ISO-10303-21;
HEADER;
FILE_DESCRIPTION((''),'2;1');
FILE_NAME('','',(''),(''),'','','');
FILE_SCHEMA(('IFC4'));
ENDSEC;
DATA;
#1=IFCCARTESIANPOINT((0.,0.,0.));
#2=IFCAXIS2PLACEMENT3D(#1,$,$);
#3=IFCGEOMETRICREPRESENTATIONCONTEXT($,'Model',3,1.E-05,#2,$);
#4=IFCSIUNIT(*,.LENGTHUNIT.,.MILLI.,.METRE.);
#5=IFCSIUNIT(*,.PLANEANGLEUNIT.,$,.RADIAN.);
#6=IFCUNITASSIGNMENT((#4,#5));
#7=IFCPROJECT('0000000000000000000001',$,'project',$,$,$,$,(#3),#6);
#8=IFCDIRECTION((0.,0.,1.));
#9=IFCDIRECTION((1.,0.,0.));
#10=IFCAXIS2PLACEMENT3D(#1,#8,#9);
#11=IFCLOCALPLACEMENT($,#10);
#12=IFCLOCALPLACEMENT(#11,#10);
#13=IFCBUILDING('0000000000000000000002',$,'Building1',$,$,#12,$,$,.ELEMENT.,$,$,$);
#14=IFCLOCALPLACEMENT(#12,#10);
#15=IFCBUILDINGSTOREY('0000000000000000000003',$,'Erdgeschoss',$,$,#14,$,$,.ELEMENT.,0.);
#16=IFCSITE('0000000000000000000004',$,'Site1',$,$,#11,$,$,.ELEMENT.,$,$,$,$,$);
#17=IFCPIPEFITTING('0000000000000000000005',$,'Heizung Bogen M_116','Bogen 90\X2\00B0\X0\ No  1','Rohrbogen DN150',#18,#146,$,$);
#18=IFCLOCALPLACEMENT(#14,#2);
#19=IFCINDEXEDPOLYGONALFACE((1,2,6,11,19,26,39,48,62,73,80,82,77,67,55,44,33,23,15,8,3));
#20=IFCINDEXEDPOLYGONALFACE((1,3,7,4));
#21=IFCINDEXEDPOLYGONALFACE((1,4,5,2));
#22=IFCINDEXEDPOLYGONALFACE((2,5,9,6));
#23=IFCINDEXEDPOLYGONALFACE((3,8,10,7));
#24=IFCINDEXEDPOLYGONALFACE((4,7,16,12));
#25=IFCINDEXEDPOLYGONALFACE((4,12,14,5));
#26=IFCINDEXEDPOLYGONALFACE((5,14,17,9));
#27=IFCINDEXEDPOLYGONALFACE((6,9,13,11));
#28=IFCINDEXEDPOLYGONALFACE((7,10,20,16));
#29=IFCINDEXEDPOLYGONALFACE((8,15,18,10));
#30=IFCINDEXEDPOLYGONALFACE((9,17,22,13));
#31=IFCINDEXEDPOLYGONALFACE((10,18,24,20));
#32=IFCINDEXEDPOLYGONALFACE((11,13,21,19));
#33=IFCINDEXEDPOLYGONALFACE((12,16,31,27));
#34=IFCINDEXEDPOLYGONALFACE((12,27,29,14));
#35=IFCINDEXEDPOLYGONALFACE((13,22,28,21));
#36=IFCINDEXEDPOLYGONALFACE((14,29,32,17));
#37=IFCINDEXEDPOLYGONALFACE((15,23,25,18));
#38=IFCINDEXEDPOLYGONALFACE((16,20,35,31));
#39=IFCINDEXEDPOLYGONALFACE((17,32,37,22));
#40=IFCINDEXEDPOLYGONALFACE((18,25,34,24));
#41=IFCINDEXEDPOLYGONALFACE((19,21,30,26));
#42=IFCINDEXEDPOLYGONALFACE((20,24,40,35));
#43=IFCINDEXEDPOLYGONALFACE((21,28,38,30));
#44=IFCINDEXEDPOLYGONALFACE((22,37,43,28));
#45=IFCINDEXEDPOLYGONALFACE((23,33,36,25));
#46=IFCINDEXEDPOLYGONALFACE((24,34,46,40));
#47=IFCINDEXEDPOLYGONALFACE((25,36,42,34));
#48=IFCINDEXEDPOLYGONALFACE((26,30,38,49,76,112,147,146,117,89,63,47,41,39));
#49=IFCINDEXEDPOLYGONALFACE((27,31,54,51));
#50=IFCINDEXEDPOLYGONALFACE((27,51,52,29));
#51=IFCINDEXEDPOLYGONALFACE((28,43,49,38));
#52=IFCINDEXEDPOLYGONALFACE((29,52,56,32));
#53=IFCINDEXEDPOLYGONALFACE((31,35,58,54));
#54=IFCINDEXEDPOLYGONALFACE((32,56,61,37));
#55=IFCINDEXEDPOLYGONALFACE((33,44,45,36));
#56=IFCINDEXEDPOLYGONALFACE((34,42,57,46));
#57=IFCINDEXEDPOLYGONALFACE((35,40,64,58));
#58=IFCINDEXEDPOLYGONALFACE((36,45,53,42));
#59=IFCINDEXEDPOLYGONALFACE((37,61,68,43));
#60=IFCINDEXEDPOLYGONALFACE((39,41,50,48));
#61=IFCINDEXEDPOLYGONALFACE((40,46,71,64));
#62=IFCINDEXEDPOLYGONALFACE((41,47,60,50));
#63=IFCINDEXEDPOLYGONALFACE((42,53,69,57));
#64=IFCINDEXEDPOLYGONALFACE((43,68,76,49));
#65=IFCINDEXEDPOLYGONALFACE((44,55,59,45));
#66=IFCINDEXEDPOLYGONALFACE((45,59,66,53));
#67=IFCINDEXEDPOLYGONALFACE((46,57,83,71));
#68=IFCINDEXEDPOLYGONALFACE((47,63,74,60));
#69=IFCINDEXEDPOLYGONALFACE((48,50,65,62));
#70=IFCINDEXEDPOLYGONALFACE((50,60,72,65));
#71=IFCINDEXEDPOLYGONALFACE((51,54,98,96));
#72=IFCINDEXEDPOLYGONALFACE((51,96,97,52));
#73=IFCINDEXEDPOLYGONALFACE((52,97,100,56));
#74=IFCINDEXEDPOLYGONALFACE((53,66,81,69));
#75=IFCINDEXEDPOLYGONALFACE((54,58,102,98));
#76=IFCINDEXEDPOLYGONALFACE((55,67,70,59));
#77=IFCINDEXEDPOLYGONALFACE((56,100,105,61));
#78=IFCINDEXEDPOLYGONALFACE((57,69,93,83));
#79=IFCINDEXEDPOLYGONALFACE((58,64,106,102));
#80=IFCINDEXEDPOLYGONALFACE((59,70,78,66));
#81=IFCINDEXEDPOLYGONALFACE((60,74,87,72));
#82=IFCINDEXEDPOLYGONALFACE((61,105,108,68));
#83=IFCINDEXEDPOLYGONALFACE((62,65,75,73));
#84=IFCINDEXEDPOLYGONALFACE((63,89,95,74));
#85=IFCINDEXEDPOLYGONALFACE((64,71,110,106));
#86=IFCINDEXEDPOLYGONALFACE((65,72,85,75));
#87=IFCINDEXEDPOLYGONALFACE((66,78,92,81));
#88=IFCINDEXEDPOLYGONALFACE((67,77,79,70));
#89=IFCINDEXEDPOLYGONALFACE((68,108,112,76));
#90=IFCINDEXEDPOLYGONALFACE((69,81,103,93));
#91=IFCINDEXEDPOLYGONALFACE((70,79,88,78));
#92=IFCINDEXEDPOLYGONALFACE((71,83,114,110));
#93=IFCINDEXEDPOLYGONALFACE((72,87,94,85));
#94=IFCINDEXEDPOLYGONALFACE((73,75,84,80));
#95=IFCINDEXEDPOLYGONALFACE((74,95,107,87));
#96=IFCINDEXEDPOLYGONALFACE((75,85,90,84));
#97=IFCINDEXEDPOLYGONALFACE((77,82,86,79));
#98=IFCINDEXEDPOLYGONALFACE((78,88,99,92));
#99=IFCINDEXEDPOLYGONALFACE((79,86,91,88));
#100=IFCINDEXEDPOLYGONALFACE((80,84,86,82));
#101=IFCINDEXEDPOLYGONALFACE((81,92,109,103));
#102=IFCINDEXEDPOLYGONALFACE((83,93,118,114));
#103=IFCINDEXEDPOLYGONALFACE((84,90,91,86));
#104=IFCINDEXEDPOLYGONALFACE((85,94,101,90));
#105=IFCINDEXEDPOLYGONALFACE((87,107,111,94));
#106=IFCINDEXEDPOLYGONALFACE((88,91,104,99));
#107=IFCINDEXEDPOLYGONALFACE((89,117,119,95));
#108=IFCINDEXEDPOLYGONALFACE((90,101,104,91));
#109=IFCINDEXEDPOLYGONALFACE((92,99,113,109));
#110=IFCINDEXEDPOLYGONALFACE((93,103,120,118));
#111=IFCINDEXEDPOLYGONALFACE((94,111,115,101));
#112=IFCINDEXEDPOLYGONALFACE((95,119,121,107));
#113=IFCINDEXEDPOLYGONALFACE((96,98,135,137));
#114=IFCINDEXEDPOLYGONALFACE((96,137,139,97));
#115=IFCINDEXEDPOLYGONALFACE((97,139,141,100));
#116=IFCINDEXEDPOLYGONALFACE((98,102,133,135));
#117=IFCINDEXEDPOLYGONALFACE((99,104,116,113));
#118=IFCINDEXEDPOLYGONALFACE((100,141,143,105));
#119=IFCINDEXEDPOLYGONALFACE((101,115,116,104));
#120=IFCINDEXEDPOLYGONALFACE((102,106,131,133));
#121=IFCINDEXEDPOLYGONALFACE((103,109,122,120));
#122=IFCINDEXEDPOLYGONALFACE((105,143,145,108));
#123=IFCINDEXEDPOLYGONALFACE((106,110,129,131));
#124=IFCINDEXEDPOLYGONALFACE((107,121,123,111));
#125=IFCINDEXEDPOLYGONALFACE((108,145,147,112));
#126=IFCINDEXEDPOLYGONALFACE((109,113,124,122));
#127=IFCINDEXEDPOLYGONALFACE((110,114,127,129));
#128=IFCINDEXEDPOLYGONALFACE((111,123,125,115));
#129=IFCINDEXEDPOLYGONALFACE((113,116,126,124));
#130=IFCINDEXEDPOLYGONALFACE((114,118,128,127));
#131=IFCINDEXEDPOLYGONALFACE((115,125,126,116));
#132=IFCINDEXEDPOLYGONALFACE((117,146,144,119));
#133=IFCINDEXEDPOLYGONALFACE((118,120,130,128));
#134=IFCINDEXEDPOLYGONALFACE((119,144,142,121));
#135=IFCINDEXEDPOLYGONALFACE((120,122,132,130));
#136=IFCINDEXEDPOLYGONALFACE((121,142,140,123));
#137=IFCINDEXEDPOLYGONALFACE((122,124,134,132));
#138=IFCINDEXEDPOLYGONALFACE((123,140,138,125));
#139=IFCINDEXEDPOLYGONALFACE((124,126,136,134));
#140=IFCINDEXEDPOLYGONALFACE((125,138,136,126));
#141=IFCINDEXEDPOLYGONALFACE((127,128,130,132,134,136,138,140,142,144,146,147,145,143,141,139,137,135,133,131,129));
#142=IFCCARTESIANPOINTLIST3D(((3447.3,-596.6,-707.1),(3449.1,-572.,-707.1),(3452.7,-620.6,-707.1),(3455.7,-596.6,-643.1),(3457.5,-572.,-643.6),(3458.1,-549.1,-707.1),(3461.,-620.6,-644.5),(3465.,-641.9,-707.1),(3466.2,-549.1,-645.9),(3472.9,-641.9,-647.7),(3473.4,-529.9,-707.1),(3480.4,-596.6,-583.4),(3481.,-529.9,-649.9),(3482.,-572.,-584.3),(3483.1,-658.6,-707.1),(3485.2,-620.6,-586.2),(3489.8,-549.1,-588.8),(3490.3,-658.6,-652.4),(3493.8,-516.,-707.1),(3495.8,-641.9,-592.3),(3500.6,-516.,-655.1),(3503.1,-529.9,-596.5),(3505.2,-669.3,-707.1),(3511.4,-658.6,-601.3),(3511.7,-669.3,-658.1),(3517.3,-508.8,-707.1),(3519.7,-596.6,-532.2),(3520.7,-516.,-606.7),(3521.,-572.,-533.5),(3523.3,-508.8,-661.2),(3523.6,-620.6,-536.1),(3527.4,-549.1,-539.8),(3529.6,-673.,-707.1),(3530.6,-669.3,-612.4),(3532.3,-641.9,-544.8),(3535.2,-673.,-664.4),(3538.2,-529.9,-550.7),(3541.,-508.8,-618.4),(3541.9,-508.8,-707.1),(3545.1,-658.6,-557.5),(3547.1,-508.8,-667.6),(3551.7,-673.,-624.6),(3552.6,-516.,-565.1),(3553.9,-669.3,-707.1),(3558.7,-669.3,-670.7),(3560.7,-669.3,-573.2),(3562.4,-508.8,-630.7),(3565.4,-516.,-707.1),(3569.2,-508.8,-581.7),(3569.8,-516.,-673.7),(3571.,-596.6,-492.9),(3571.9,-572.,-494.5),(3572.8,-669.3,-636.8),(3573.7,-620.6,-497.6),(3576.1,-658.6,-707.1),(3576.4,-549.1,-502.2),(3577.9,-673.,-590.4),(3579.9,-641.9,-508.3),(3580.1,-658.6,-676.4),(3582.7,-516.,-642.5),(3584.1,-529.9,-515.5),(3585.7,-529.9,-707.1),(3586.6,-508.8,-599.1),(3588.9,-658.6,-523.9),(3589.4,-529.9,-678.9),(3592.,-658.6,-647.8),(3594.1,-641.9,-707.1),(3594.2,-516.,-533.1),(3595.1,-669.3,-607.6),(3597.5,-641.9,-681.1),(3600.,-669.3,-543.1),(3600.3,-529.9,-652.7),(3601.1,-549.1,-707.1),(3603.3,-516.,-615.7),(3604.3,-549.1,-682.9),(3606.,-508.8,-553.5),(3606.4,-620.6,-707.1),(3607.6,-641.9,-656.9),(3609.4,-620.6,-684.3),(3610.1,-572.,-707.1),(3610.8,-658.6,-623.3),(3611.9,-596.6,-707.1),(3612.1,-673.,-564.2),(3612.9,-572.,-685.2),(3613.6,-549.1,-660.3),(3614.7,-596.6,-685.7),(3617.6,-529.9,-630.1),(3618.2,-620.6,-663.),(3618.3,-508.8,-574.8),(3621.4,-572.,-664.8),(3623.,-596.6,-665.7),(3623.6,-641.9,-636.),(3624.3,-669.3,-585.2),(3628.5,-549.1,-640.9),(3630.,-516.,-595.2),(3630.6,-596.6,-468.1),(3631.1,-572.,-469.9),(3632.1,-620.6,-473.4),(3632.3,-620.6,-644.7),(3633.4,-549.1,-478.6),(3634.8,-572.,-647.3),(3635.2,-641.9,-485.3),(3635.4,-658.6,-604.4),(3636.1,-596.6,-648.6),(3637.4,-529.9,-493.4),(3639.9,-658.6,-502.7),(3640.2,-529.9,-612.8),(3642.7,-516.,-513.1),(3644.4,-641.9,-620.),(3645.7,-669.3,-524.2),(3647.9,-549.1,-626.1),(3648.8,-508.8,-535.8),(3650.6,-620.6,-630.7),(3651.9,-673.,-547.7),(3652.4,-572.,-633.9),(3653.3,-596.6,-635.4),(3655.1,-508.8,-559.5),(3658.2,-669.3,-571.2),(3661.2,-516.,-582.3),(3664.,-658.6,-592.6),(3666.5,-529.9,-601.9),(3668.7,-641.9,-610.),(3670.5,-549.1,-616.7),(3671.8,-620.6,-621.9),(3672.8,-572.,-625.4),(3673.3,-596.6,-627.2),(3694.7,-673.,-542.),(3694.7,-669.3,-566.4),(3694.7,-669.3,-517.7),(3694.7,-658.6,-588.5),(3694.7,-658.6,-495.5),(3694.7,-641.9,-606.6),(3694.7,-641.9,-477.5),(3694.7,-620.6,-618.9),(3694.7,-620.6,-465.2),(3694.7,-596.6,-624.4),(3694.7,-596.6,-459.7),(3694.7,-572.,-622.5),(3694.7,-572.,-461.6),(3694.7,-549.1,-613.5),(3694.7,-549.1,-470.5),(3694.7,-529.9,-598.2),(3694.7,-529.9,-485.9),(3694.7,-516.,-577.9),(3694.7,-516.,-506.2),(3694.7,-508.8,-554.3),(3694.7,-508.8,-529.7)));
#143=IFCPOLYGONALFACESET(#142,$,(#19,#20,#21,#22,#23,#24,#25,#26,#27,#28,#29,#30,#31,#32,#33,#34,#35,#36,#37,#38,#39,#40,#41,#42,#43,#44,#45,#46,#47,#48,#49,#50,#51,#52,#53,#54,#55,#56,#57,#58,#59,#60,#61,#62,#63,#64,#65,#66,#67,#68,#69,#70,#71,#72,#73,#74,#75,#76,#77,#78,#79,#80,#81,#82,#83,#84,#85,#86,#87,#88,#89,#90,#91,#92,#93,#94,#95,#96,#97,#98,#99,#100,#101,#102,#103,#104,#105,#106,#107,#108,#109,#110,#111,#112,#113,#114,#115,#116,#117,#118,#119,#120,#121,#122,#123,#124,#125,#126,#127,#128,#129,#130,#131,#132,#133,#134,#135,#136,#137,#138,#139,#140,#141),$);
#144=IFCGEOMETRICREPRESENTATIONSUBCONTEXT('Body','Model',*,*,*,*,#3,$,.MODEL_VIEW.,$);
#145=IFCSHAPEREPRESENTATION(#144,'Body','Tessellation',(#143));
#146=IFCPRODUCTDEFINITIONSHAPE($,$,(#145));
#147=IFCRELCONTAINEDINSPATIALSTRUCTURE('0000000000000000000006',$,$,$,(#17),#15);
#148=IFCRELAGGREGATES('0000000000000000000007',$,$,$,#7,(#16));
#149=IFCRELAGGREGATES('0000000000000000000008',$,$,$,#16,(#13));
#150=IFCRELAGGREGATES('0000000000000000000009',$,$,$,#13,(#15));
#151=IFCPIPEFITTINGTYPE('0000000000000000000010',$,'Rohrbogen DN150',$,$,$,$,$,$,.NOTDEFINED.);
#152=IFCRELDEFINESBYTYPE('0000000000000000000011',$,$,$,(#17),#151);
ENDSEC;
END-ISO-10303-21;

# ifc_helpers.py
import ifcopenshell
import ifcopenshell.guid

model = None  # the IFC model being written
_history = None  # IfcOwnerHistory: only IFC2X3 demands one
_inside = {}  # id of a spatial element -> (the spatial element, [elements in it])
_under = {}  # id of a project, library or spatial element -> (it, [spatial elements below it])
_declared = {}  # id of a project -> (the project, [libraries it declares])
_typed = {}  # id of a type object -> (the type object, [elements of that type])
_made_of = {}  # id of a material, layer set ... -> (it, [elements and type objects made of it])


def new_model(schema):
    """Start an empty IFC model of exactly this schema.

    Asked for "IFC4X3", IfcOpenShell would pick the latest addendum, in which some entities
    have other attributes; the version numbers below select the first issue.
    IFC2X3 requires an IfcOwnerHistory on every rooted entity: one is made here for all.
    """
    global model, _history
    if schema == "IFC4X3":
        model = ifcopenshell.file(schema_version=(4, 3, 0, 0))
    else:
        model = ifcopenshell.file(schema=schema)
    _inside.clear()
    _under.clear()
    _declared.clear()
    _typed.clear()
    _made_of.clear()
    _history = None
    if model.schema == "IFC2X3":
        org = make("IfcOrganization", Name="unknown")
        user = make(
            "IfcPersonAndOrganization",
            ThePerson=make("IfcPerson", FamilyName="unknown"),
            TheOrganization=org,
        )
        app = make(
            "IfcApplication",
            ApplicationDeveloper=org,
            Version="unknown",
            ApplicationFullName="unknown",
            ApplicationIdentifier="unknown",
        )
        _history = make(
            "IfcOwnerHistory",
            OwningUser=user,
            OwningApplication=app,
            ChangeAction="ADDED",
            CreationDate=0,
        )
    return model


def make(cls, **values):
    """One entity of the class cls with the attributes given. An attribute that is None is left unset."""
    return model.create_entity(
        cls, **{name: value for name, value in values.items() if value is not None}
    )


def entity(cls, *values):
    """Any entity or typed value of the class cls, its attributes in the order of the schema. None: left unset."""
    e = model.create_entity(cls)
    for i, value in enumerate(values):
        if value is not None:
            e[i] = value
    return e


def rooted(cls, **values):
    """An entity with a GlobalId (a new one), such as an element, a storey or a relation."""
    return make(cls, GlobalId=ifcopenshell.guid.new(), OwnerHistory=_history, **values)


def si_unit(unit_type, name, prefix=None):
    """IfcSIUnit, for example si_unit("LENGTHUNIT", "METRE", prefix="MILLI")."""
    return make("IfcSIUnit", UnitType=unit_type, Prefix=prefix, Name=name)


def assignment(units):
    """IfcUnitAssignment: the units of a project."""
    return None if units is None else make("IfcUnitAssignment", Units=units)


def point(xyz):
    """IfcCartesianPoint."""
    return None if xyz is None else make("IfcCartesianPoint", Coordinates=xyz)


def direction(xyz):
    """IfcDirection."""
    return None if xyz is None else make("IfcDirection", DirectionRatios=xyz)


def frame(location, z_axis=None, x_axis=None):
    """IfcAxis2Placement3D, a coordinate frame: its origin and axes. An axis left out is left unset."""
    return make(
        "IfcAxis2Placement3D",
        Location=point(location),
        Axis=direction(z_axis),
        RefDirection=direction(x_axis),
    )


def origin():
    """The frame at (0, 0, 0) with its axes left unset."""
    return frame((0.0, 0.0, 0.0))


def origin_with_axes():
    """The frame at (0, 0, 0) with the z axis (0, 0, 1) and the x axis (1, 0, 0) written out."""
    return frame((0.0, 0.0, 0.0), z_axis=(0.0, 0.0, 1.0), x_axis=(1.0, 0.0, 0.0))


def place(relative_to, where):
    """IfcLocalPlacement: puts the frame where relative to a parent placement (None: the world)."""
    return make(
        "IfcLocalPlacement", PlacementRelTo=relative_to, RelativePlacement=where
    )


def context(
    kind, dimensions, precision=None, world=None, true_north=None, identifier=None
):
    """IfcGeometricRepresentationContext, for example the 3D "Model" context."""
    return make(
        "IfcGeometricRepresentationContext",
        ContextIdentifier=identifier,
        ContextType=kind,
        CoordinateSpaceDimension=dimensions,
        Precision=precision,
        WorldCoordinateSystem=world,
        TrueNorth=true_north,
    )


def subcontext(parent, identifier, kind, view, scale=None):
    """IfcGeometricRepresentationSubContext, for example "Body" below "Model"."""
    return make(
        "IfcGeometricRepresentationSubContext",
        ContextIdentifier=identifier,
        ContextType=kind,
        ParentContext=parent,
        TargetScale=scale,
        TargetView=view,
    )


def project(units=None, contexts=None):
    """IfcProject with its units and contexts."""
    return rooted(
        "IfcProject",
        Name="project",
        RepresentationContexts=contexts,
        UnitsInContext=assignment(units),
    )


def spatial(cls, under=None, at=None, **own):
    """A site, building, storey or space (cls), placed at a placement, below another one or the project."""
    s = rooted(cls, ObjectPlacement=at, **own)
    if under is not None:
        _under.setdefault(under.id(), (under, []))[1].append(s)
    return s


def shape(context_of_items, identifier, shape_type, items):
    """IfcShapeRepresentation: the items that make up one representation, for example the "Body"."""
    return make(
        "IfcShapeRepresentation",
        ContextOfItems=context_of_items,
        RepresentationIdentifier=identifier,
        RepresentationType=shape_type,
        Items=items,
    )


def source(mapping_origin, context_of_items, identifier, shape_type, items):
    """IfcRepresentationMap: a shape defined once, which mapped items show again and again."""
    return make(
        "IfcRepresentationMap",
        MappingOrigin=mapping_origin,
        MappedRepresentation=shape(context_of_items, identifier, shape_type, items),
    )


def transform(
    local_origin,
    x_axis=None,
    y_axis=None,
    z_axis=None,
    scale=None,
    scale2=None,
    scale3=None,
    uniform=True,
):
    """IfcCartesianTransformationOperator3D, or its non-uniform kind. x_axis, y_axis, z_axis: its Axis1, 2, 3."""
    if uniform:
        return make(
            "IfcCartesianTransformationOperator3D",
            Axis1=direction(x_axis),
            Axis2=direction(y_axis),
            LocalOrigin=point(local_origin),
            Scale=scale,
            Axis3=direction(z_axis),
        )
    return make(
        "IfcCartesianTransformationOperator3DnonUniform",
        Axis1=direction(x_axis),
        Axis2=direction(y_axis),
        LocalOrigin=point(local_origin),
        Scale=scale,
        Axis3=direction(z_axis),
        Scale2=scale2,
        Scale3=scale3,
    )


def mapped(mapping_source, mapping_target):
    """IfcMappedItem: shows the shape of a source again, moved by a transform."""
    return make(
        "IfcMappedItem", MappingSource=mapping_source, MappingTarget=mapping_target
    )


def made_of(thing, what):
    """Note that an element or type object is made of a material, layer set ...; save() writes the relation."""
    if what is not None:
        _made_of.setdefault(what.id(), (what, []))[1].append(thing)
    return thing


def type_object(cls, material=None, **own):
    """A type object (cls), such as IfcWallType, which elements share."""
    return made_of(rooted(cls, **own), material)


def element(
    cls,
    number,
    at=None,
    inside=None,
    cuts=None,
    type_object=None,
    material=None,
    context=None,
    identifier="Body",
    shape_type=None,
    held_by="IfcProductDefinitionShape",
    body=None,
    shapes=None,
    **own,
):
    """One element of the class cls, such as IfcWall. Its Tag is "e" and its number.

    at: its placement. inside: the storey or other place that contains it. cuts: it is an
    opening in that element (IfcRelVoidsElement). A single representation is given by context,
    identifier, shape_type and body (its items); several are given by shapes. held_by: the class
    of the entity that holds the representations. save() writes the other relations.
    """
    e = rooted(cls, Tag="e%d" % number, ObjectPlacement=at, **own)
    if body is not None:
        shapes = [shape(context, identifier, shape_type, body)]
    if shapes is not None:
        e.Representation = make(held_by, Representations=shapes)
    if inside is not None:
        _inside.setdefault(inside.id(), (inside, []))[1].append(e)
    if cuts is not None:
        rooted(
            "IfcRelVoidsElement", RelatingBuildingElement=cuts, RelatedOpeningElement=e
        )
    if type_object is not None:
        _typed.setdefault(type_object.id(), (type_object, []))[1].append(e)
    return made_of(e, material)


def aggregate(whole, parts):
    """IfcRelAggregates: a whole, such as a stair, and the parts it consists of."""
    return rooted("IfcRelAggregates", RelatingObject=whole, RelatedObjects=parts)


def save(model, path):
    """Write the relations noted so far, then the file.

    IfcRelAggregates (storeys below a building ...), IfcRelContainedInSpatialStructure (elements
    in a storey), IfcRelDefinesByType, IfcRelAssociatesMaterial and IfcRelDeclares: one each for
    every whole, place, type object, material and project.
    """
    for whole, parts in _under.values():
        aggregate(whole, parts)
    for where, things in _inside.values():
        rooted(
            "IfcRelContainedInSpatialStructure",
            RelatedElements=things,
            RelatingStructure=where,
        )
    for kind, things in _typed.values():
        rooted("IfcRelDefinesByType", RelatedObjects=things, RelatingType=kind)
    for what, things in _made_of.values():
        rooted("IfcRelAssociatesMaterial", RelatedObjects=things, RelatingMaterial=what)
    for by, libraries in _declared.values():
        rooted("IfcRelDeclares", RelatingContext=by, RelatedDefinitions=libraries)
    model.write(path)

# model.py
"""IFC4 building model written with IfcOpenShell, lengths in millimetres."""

from ifc_helpers import new_model, entity, si_unit, frame, origin, origin_with_axes, place, context, subcontext, project, spatial, source, transform, mapped, type_object, element, save


model = new_model("IFC4")

# Units and contexts
model_context = context("Model", 3, precision=1e-05, world=origin())
body_context = subcontext(model_context, "Body", "Model", "MODEL_VIEW")
ifc_project = project(units=[si_unit("LENGTHUNIT", "METRE", prefix="MILLI"), si_unit("PLANEANGLEUNIT", "RADIAN")], contexts=[model_context])

# Site, building, storey
site_placement = place(None, origin_with_axes())
site = spatial("IfcSite", under=ifc_project, at=site_placement, Name="Site1", CompositionType="ELEMENT")
building_placement = place(site_placement, origin_with_axes())
building = spatial("IfcBuilding", under=site, at=building_placement, Name="Building1", CompositionType="ELEMENT")
storey_placement = place(building_placement, origin_with_axes())
storey = spatial("IfcBuildingStorey", under=building, at=storey_placement, Name="Erdgeschoss", CompositionType="ELEMENT", Elevation=0.0)

# Pipe fitting
pipe_fitting_type_1 = type_object("IfcPipeFittingType", Name="Rohrbogen DN150", PredefinedType="NOTDEFINED")
shared_shape_1 = source(origin_with_axes(), body_context, "Body", "SolidModel", [
    entity("IfcRevolvedAreaSolid", entity("IfcCircleProfileDef", "AREA", None, entity("IfcAxis2Placement2D", entity("IfcCartesianPoint", [0.0, 0.0]), entity("IfcDirection", [1.0, 0.0])), 82.5), entity("IfcAxis2Placement3D", entity("IfcCartesianPoint", [123.8, -41.3, 0.0]), entity("IfcDirection", [-1.0, 0.0, 0.0]), entity("IfcDirection", [0.0, 0.0, 1.0])), entity("IfcAxis1Placement", entity("IfcCartesianPoint", [0.0, 165.1, 0.0]), entity("IfcDirection", [-1.0, 0.0, 0.0])), 1.570796),
])
pipe_fitting_1_placement = place(storey_placement, frame((3570.9, -590.4, -583.3), z_axis=(0.0, 0.0, 1.0), x_axis=(1.0, 0.0, 0.0)))
element("IfcPipeFitting", 1, at=pipe_fitting_1_placement, inside=storey, type_object=pipe_fitting_type_1, Name="Heizung Bogen M_116", Description="Bogen 90° No  1", ObjectType="Rohrbogen DN150", context=body_context, shape_type="MappedRepresentation", body=[
    mapped(shared_shape_1, transform((0.0, 0.0, 0.0), x_axis=(0.0, 0.0, -1.0), y_axis=(1.0, 0.0, 0.0), z_axis=(0.0, -1.0, 0.0), scale=1.0)),
])

save(model, "model.ifc")
